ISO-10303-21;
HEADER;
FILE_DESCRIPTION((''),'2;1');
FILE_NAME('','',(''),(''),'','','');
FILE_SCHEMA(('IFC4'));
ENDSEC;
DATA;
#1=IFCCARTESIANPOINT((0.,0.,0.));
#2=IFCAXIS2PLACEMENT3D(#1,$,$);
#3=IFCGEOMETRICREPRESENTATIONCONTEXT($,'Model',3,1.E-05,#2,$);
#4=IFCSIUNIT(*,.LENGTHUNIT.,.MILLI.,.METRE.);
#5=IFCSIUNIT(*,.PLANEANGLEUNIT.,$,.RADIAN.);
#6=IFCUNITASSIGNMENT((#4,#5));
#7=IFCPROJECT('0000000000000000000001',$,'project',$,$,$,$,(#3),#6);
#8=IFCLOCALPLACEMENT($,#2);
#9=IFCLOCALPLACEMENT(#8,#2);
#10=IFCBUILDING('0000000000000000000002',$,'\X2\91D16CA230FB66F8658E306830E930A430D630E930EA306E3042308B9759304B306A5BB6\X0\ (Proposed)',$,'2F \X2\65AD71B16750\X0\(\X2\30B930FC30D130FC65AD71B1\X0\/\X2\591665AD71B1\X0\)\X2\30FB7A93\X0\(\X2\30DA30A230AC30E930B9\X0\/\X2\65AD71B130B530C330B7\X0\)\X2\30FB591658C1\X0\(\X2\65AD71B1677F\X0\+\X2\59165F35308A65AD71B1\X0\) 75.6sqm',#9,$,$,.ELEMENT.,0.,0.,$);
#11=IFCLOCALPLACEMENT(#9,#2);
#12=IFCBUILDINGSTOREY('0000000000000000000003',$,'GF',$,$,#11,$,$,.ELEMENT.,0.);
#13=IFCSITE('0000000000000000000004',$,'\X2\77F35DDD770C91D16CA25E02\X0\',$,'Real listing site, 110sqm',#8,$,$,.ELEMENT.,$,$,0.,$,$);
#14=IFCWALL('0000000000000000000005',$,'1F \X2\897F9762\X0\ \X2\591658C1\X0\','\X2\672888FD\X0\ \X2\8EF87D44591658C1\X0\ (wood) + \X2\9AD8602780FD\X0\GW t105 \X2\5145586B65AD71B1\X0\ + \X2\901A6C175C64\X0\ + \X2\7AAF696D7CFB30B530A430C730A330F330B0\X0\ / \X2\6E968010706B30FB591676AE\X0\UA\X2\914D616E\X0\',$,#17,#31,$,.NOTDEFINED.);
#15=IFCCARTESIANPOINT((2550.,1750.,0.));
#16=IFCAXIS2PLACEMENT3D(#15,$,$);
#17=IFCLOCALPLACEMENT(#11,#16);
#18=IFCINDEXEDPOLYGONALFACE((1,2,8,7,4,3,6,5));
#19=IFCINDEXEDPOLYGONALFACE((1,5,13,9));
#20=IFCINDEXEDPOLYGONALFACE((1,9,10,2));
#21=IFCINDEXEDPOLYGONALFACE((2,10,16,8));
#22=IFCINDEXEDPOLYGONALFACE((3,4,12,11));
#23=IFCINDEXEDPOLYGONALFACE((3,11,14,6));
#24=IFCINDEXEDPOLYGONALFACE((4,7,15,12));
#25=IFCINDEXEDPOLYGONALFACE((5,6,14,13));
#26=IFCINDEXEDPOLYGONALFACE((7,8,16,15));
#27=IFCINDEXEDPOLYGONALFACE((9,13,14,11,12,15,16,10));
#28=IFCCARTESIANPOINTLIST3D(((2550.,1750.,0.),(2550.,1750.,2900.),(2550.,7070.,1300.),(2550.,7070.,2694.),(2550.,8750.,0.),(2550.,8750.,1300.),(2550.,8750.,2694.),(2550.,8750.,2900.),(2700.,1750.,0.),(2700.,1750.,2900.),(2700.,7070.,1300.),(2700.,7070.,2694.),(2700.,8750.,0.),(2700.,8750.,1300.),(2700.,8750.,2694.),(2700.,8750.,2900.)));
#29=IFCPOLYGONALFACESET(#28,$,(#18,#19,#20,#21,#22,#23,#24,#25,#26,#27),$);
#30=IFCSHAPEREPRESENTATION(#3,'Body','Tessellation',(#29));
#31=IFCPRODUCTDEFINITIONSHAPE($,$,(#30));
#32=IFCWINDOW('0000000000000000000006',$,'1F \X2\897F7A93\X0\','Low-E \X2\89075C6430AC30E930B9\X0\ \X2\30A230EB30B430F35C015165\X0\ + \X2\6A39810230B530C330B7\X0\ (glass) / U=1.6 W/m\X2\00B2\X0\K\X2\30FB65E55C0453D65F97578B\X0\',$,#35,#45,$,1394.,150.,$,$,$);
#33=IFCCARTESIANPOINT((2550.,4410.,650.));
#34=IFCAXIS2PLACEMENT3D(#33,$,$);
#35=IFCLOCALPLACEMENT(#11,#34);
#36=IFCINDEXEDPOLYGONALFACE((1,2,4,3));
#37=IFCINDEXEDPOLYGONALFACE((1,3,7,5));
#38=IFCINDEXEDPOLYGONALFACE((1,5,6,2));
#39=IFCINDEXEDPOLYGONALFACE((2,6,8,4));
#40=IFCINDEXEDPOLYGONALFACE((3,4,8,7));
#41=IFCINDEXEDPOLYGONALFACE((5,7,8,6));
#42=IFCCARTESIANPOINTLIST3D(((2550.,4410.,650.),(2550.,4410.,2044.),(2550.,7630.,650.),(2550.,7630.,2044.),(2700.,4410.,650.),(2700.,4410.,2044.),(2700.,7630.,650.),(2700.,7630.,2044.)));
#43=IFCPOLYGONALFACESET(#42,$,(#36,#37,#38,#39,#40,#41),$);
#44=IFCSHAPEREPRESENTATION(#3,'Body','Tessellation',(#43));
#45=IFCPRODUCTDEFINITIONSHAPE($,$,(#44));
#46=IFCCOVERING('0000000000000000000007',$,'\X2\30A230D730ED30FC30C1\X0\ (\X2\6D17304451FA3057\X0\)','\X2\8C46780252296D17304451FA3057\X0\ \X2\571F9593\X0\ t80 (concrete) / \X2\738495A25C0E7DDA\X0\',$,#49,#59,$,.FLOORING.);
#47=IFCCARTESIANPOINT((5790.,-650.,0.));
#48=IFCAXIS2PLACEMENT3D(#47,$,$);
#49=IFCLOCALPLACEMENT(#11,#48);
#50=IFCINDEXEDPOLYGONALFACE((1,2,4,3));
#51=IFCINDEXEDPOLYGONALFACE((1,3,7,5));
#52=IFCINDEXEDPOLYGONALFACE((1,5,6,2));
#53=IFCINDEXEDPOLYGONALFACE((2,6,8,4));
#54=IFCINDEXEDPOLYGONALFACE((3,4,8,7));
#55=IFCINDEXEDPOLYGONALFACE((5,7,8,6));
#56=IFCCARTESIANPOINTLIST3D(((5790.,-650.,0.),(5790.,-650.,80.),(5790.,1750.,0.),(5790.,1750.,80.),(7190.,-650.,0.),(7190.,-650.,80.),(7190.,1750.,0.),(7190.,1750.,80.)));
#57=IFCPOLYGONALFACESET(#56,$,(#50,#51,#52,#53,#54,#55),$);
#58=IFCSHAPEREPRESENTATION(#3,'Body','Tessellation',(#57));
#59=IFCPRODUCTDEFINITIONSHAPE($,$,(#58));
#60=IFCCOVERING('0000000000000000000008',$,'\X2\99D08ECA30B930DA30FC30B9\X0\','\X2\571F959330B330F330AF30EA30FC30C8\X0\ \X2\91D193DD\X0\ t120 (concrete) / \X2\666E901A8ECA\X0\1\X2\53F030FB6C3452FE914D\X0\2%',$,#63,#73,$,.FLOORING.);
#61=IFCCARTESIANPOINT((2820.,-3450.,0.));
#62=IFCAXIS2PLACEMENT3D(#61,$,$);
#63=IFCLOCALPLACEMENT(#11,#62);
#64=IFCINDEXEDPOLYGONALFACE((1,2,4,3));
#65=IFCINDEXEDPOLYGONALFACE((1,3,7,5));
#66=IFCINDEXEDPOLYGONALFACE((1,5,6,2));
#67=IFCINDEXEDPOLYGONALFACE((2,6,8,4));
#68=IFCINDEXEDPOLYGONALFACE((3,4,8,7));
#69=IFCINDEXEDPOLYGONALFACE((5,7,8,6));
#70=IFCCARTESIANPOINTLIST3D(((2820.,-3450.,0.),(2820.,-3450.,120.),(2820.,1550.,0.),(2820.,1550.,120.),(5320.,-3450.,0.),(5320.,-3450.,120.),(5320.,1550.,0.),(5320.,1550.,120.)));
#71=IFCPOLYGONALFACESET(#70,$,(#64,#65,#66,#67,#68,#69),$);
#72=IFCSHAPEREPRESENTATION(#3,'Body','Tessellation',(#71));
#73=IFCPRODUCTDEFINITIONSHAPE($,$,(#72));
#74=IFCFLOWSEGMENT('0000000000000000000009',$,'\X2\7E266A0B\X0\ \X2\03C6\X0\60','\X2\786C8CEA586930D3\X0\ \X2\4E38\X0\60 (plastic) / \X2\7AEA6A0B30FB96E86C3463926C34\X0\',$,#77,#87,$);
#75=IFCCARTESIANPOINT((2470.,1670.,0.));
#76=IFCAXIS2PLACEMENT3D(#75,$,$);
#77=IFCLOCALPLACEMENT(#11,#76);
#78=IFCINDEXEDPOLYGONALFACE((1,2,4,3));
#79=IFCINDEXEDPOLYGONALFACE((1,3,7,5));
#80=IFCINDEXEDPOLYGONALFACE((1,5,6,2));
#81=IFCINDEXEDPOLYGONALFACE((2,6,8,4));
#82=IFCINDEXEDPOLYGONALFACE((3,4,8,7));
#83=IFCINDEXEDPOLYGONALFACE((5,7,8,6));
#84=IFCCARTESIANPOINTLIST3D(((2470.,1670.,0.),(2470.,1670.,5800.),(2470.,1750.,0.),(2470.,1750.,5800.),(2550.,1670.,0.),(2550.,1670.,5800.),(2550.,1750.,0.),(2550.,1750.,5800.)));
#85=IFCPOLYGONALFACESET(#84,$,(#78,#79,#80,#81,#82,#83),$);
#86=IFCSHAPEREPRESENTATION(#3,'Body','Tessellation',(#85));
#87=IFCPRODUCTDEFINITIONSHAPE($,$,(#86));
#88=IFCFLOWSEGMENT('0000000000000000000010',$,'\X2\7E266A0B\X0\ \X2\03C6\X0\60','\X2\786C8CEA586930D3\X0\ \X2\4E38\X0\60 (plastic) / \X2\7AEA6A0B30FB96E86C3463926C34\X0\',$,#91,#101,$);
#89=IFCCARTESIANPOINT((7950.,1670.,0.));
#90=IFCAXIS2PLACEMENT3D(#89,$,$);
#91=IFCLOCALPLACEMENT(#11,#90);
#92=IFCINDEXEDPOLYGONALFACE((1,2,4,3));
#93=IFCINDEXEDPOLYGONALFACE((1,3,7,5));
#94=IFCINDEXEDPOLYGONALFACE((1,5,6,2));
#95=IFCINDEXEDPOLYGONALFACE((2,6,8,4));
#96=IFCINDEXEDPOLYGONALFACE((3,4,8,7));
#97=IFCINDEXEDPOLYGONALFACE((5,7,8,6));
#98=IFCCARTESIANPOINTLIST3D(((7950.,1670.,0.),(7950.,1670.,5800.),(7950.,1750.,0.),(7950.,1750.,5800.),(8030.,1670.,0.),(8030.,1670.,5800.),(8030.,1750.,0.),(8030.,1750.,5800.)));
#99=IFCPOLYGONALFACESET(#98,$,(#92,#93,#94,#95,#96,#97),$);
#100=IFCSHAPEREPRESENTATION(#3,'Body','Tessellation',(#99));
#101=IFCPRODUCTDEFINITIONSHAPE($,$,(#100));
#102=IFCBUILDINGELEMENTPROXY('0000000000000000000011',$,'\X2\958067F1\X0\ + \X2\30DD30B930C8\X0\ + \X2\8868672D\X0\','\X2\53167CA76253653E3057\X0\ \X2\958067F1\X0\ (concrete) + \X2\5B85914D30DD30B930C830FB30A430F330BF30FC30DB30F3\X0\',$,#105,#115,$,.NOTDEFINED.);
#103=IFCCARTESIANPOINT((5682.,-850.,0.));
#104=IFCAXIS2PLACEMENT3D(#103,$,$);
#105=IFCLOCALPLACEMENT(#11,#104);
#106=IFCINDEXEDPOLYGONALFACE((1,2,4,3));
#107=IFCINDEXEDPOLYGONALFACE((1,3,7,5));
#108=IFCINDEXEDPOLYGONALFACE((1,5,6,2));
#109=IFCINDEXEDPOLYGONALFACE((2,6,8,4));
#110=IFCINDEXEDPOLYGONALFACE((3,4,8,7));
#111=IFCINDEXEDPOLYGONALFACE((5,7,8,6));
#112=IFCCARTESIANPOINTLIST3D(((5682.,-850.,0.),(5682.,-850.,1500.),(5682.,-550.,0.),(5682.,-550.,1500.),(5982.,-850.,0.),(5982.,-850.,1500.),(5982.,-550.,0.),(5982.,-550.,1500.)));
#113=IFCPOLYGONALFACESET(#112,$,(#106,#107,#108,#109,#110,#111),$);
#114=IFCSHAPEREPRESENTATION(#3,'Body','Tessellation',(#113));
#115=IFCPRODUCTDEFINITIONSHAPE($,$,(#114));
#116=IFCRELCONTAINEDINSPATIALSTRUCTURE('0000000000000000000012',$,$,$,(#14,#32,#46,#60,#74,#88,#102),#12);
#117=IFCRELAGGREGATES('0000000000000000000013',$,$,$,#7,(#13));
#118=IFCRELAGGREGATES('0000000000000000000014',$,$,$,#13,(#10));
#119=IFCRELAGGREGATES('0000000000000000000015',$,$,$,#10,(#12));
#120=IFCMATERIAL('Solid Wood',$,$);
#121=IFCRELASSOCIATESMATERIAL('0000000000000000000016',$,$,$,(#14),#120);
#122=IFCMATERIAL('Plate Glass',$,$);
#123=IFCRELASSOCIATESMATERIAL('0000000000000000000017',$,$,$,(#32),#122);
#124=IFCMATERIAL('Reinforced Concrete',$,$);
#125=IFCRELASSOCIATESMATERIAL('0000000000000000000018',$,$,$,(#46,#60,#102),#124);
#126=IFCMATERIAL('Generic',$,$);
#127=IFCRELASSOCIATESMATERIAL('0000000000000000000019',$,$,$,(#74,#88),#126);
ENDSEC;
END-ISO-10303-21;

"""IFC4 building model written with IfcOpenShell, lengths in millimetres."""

from ifc_helpers import new_model, si_unit, frame, frame_2d, origin, place, context, project, spatial, rectangle, extrude, material, element, fill, save


model = new_model("IFC4")

# Units and contexts
model_context = context("Model", 3, precision=1e-05, world=origin())
ifc_project = project(units=[si_unit("LENGTHUNIT", "METRE", prefix="MILLI"), si_unit("PLANEANGLEUNIT", "RADIAN")], contexts=[model_context])

# Site, building, storey
site_placement = place(None, origin())
site = spatial("IfcSite", under=ifc_project, at=site_placement, Name="石川県金沢市", ObjectType="Real listing site, 110sqm", CompositionType="ELEMENT", RefElevation=0.0)
building_placement = place(site_placement, origin())
building = spatial("IfcBuilding", under=site, at=building_placement, Name="金沢・書斎とライブラリのある静かな家 (Proposed)", ObjectType="2F 断熱材(スーパー断熱/外断熱)・窓(ペアガラス/断熱サッシ)・外壁(断熱板+外張り断熱) 75.6sqm", CompositionType="ELEMENT", ElevationOfRefHeight=0.0, ElevationOfTerrain=0.0)
storey_placement = place(building_placement, origin())
storey = spatial("IfcBuildingStorey", under=building, at=storey_placement, Name="GF", CompositionType="ELEMENT", Elevation=0.0)

# Shared definitions
ifc_material_1 = material(Name="Solid Wood")

# Shared definitions
ifc_material_2 = material(Name="Reinforced Concrete")

# Shared definitions
ifc_material_3 = material(Name="Plate Glass")

# Wall, opening, window
wall_1_placement = place(storey_placement, frame((2550.0, 1750.0, 0.0)))
wall_1 = element("IfcWall", 1, at=wall_1_placement, inside=storey, material=ifc_material_1, Name="1F 西面 外壁", Description="木製 軸組外壁 (wood) + 高性能GW t105 充填断熱 + 通気層 + 窯業系サイディング / 準耐火・外皮UA配慮", PredefinedType="NOTDEFINED", context=model_context, shape_type="SweptSolid", body=[
    extrude(rectangle(XDim=150.0, YDim=7000.0, at=frame_2d((75.0, 3500.0))), frame((2550.0, 1750.0, 0.0)), (0.0, 0.0, 1.0), 2900.0),
])
opening_1_placement = place(storey_placement, frame((2550.0, 4410.0, 650.0)))
opening_1 = element("IfcOpeningElement", 2, at=opening_1_placement, cuts=wall_1, PredefinedType="NOTDEFINED", context=model_context, shape_type="SweptSolid", body=[
    extrude(rectangle(XDim=150.0, YDim=3220.0, at=frame_2d((75.0, 1610.0))), frame((2550.0, 4410.0, 650.0)), (0.0, 0.0, 1.0), 1394.0),
])
window_1_placement = place(storey_placement, frame((2550.0, 4410.0, 650.0)))
window_1 = element("IfcWindow", 3, at=window_1_placement, inside=storey, material=ifc_material_3, Name="1F 西窓", Description="Low-E 複層ガラス アルゴン封入 + 樹脂サッシ (glass) / U=1.6 W/m²K・日射取得型", OverallHeight=1394.0, OverallWidth=150.0, context=model_context, shape_type="SweptSolid", body=[
    extrude(rectangle(XDim=150.0, YDim=3220.0, at=frame_2d((75.0, 1610.0))), frame((2550.0, 4410.0, 650.0)), (0.0, 0.0, 1.0), 1394.0),
])
fill(opening_1, window_1)

# Coverings
covering_1_placement = place(storey_placement, frame((5790.0, -650.0, 0.0)))
element("IfcCovering", 4, at=covering_1_placement, inside=storey, material=ifc_material_2, Name="アプローチ (洗い出し)", Description="豆砂利洗い出し 土間 t80 (concrete) / 玄関導線", PredefinedType="FLOORING", context=model_context, shape_type="SweptSolid", body=[
    extrude(rectangle(XDim=1400.0, YDim=2400.0, at=frame_2d((700.0, 1200.0))), frame((5790.0, -650.0, 0.0)), (0.0, 0.0, 1.0), 80.0),
])
covering_2_placement = place(storey_placement, frame((2820.0, -3450.0, 0.0)))
element("IfcCovering", 5, at=covering_2_placement, inside=storey, material=ifc_material_2, Name="駐車スペース", Description="土間コンクリート 金鏝 t120 (concrete) / 普通車1台・水勾配2%", PredefinedType="FLOORING", context=model_context, shape_type="SweptSolid", body=[
    extrude(rectangle(XDim=2500.0, YDim=5000.0, at=frame_2d((1250.0, 2500.0))), frame((2820.0, -3450.0, 0.0)), (0.0, 0.0, 1.0), 120.0),
])

# Flow segments
ifc_material_4 = material(Name="Generic")
flow_segment_1_placement = place(storey_placement, frame((2470.0, 1670.0, 0.0)))
element("IfcFlowSegment", 6, at=flow_segment_1_placement, inside=storey, material=ifc_material_4, Name="縦樋 φ60", Description="硬質塩ビ 丸60 (plastic) / 竪樋・雨水排水", context=model_context, shape_type="SweptSolid", body=[
    extrude(rectangle(XDim=80.0, YDim=80.0, at=frame_2d((40.0, 40.0))), frame((2470.0, 1670.0, 0.0)), (0.0, 0.0, 1.0), 5800.0),
])
flow_segment_2_placement = place(storey_placement, frame((7950.0, 1670.0, 0.0)))
element("IfcFlowSegment", 7, at=flow_segment_2_placement, inside=storey, material=ifc_material_4, Name="縦樋 φ60", Description="硬質塩ビ 丸60 (plastic) / 竪樋・雨水排水", context=model_context, shape_type="SweptSolid", body=[
    extrude(rectangle(XDim=80.0, YDim=80.0, at=frame_2d((40.0, 40.0))), frame((7950.0, 1670.0, 0.0)), (0.0, 0.0, 1.0), 5800.0),
])

# Building element proxy
proxy_placement = place(storey_placement, frame((5682.0, -850.0, 0.0)))
element("IfcBuildingElementProxy", 8, at=proxy_placement, inside=storey, material=ifc_material_2, Name="門柱 + ポスト + 表札", Description="化粧打放し 門柱 (concrete) + 宅配ポスト・インターホン", PredefinedType="NOTDEFINED", context=model_context, shape_type="SweptSolid", body=[
    extrude(rectangle(XDim=300.0, YDim=300.0, at=frame_2d((150.0, 150.0))), frame((5682.0, -850.0, 0.0)), (0.0, 0.0, 1.0), 1500.0),
])

save(model, "model.ifc")
